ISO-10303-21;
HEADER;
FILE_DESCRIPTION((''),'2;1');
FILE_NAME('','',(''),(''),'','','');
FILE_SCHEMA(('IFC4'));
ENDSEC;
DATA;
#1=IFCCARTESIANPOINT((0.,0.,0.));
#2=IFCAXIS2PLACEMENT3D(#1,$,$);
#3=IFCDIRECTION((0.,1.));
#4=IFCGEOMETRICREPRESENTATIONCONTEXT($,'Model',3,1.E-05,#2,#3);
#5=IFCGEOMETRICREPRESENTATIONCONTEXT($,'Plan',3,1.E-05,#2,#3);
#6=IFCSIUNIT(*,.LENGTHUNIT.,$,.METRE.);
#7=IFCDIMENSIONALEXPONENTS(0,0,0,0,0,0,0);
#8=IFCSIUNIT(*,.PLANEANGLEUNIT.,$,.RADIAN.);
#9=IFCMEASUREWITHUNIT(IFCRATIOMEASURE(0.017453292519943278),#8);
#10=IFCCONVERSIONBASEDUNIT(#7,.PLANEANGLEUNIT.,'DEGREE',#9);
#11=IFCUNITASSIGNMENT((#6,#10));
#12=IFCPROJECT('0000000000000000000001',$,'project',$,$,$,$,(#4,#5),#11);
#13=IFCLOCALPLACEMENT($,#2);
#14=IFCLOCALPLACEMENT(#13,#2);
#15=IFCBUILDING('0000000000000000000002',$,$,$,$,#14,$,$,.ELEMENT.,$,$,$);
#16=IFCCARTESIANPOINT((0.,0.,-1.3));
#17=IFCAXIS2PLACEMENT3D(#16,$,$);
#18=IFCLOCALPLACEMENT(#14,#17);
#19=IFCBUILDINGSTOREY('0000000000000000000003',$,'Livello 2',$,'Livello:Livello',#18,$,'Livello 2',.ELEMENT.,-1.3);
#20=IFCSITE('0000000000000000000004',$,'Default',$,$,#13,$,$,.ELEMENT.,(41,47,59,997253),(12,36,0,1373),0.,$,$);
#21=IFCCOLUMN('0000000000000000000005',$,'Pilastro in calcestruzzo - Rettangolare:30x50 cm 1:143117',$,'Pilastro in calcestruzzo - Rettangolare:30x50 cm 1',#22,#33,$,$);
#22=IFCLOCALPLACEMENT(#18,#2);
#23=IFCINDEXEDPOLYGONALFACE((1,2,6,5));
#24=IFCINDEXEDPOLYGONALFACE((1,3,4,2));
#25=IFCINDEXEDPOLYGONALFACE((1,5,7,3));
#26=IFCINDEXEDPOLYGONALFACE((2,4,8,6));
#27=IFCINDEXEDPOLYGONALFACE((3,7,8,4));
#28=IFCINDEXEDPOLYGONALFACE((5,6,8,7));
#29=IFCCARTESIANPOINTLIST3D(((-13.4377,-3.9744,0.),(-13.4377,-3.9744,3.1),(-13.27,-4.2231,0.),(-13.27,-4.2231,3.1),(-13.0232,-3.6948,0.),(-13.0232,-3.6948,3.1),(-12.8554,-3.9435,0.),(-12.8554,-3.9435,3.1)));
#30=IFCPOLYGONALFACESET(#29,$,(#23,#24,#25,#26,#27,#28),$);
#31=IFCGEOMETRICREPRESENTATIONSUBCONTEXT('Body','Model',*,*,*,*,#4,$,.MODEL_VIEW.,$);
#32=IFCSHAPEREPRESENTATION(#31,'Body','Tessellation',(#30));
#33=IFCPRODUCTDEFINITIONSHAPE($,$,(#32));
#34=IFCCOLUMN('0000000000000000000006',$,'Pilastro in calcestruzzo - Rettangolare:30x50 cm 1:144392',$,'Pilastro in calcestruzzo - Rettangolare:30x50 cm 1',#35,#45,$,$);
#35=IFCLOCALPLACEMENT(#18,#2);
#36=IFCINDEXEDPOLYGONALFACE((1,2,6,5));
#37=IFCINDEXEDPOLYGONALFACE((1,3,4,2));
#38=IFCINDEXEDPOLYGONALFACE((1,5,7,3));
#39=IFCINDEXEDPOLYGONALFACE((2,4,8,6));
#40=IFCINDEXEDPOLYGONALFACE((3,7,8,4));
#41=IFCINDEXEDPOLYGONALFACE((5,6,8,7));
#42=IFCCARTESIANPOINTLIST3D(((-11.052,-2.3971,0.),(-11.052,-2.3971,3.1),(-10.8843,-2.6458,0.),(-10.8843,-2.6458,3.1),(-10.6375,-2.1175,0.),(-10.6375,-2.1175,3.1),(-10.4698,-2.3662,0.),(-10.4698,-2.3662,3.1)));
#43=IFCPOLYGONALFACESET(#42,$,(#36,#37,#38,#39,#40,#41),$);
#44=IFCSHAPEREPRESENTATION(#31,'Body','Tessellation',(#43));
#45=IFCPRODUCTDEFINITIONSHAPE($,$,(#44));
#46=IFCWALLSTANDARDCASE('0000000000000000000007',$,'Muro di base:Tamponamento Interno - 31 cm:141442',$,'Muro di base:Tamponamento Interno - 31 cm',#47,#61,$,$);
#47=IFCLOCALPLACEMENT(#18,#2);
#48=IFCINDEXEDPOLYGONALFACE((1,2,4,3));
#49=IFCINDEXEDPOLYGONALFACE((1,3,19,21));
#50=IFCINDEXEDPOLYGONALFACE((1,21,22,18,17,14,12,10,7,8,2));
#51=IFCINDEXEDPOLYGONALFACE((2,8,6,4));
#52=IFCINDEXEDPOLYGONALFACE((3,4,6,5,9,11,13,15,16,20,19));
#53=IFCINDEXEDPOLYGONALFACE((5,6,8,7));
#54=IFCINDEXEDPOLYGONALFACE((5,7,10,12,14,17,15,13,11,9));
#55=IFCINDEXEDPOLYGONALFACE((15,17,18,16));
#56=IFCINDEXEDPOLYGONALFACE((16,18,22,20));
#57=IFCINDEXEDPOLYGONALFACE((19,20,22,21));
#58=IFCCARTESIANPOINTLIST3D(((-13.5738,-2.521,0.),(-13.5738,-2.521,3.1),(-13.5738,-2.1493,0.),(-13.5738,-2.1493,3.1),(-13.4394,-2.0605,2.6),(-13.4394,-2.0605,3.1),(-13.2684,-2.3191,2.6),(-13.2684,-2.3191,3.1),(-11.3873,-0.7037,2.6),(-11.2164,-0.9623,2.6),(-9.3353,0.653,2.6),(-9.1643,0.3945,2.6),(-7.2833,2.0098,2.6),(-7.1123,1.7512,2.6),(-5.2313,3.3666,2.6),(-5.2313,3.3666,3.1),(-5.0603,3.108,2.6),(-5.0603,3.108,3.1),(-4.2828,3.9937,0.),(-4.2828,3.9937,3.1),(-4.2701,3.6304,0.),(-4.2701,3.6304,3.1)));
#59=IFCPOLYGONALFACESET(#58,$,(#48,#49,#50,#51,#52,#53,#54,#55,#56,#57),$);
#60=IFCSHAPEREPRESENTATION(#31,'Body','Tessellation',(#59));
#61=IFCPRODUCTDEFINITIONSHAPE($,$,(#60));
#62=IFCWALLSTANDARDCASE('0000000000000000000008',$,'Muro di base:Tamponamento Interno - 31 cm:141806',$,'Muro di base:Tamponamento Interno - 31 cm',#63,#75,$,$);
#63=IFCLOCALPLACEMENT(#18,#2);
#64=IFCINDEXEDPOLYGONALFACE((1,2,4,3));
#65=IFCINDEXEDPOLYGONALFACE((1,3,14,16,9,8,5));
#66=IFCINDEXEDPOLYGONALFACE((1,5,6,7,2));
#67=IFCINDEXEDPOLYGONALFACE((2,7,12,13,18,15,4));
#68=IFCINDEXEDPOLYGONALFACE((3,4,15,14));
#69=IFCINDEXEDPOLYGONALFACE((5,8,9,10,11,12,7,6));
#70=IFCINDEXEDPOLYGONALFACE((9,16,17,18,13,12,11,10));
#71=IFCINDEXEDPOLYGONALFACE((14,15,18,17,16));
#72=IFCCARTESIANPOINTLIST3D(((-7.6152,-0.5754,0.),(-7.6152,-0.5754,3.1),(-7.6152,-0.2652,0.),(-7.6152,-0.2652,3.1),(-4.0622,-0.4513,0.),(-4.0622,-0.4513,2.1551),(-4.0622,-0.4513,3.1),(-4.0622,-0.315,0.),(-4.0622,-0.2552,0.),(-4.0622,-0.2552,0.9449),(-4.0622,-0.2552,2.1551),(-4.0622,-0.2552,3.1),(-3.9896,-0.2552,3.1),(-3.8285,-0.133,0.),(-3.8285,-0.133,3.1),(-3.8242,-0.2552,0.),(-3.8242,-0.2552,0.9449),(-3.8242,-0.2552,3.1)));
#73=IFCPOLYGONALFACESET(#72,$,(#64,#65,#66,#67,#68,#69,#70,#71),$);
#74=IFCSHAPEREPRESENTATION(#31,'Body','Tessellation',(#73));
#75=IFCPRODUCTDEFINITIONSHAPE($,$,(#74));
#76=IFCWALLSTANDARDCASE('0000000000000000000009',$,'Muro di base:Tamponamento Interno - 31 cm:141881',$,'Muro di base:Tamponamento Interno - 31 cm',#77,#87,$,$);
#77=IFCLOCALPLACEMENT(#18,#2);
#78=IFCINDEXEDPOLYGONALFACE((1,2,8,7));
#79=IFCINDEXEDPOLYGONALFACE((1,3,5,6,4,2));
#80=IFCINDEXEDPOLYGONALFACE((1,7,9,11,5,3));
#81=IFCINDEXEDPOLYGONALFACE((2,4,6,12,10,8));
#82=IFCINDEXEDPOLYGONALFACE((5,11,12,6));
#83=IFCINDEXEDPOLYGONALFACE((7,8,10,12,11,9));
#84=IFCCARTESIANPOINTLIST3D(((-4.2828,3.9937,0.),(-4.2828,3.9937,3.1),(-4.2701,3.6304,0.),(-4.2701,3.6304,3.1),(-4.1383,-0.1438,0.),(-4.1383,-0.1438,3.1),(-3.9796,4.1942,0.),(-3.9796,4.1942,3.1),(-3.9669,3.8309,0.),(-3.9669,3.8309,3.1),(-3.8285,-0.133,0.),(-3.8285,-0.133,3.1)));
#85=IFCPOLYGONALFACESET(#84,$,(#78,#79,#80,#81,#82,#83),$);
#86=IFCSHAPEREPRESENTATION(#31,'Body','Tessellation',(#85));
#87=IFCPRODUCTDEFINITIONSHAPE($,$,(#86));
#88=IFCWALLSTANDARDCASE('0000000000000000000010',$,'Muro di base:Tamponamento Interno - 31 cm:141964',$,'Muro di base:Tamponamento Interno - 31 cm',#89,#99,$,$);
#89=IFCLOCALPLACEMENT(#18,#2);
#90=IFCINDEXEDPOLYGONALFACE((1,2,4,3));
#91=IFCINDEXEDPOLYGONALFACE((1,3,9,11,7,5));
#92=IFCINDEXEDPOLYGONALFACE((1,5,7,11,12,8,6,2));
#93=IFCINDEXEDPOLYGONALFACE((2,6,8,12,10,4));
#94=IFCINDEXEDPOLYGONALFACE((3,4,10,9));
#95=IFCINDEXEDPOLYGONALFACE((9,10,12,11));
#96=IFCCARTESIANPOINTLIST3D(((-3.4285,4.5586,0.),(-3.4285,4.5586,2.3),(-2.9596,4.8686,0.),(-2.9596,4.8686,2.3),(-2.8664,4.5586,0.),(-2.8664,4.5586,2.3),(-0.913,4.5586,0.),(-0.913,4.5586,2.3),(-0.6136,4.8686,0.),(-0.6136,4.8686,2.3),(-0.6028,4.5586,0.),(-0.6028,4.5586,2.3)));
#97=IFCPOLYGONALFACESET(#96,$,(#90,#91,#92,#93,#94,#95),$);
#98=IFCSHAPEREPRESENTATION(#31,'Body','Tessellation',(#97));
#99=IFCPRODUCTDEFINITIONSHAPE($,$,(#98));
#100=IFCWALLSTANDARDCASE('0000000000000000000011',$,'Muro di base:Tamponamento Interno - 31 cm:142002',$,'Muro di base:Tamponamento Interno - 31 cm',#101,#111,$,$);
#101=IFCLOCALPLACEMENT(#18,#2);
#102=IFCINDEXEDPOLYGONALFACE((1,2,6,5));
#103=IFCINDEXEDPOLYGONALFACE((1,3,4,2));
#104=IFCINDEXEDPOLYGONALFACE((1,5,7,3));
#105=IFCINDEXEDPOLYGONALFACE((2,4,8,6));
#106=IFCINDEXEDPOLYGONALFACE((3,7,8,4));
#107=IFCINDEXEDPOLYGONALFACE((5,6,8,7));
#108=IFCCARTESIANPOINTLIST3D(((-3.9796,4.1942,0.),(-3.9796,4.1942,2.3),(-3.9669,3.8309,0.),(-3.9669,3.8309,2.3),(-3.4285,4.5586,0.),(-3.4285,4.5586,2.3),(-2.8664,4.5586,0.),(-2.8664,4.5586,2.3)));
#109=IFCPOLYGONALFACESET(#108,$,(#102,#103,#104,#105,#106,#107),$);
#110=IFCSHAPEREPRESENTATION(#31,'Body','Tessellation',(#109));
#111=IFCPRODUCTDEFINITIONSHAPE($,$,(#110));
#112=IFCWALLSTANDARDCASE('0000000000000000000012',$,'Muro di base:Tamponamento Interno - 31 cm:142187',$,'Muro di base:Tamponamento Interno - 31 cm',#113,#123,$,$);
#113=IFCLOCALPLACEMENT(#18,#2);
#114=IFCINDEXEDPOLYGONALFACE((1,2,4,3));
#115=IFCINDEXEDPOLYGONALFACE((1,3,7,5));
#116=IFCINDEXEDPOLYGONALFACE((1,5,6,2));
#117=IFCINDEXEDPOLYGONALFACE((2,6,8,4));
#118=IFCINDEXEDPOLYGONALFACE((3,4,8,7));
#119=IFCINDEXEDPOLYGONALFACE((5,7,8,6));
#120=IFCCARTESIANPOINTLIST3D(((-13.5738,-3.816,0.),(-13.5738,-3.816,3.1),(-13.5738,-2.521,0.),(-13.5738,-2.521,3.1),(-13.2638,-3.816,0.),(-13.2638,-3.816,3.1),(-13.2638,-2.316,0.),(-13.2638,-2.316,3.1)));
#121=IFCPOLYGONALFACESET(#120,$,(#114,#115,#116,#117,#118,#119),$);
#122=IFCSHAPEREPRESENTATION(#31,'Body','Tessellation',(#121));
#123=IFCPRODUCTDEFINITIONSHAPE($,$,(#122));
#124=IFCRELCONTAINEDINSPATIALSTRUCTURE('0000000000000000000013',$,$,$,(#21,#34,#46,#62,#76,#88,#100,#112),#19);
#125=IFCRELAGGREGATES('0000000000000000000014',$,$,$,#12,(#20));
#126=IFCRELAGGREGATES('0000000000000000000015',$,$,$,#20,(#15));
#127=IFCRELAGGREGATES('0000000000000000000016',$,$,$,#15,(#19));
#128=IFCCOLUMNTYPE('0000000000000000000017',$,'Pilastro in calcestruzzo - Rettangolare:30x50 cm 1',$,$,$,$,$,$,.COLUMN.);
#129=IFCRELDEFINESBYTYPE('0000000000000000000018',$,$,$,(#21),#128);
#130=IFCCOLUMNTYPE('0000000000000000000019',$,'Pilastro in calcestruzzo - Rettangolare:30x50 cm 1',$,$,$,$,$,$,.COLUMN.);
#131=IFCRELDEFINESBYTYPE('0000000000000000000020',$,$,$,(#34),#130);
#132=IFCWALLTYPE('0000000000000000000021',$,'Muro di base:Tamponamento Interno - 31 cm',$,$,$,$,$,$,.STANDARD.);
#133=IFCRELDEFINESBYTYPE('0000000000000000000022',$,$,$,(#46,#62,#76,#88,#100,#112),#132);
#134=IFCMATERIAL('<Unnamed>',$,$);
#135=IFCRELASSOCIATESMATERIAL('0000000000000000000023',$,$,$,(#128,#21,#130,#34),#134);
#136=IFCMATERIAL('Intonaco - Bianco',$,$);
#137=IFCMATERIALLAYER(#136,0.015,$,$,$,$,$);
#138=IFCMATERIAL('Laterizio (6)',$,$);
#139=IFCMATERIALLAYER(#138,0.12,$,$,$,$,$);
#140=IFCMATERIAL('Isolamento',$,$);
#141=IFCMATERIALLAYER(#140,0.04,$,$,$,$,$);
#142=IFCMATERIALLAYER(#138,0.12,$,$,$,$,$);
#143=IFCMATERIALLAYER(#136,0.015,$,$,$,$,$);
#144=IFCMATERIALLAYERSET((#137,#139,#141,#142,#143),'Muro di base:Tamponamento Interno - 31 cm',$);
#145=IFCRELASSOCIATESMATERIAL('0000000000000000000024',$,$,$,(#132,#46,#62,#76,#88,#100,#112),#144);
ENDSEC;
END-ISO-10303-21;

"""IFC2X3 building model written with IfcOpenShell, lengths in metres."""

from ifc_helpers import new_model, entity, si_unit, converted_unit, direction, frame, frame_2d, origin, origin_2d_with_axis, place, context, subcontext, project, spatial, polyline, rectangle, outline, extrude, clip, bounded_halfspace, source, transform, mapped, material, layer, layer_set, layer_usage, type_object, type_shapes, element, save


model = new_model("IFC2X3")

# Units and contexts
model_context = context("Model", 3, precision=1e-05, world=origin(), true_north=direction((0.0, 1.0)))
plan_context = context("Plan", 3, precision=1e-05, world=origin(), true_north=direction((0.0, 1.0)))
body_context = subcontext(model_context, "Body", "Model", "MODEL_VIEW")
ifc_project = project(units=[si_unit("LENGTHUNIT", "METRE"), converted_unit("PLANEANGLEUNIT", "DEGREE", entity("IfcRatioMeasure", 0.017453292519943278), si_unit("PLANEANGLEUNIT", "RADIAN"), dimensions=[0, 0, 0, 0, 0, 0, 0])], contexts=[model_context, plan_context])

# Site, building, storey
site_placement = place(None, origin())
site = spatial("IfcSite", under=ifc_project, at=site_placement, Name="Default", CompositionType="ELEMENT", RefLatitude=(41, 47, 59, 997253), RefLongitude=(12, 36, 0, 1373), RefElevation=0.0)
building_placement = place(site_placement, origin())
building = spatial("IfcBuilding", under=site, at=building_placement, CompositionType="ELEMENT")
storey_placement = place(building_placement, frame((0.0, 0.0, -1.3)))
storey = spatial("IfcBuildingStorey", under=building, at=storey_placement, Name="Livello 2", ObjectType="Livello:Livello", LongName="Livello 2", CompositionType="ELEMENT", Elevation=-1.3)

# Columns
ifc_material_1 = material(Name="<Unnamed>")
column_type_1 = type_object("IfcColumnType", Name="Pilastro in calcestruzzo - Rettangolare:30x50 cm 1", PredefinedType="COLUMN", material=ifc_material_1)
shared_shape_1 = source(origin(), body_context, "Body", "SweptSolid", [
    extrude(rectangle(XDim=0.3, YDim=0.5, at=origin_2d_with_axis()), frame((-13.1466, -3.959, -1.3), z_axis=(0.0, 0.0, 1.0), x_axis=(-0.559193, 0.829038, 0.0)), (0.0, 0.0, 1.0), 3.1),
])
type_shapes(column_type_1, [shared_shape_1])
column_1_placement = place(storey_placement, frame((0.0, 0.0, 1.3)))
element("IfcColumn", 1, at=column_1_placement, inside=storey, type_object=column_type_1, material=ifc_material_1, Name="Pilastro in calcestruzzo - Rettangolare:30x50 cm 1:143117", ObjectType="Pilastro in calcestruzzo - Rettangolare:30x50 cm 1", context=body_context, shape_type="MappedRepresentation", body=[
    mapped(shared_shape_1, transform((0.0, 0.0, 0.0), scale=1.0)),
])
column_type_2 = type_object("IfcColumnType", Name="Pilastro in calcestruzzo - Rettangolare:30x50 cm 1", PredefinedType="COLUMN", material=ifc_material_1)
shared_shape_2 = source(origin(), body_context, "Body", "SweptSolid", [
    extrude(rectangle(XDim=0.3, YDim=0.5, at=frame_2d((0.0, 0.0), x_axis=(1.0, 0.0))), frame((-10.7609, -2.3816, -1.3), z_axis=(0.0, 0.0, 1.0), x_axis=(-0.559193, 0.829038, 0.0)), (0.0, 0.0, 1.0), 3.1),
])
type_shapes(column_type_2, [shared_shape_2])
column_2_placement = place(storey_placement, frame((0.0, 0.0, 1.3)))
element("IfcColumn", 2, at=column_2_placement, inside=storey, type_object=column_type_2, material=ifc_material_1, Name="Pilastro in calcestruzzo - Rettangolare:30x50 cm 1:144392", ObjectType="Pilastro in calcestruzzo - Rettangolare:30x50 cm 1", context=body_context, shape_type="MappedRepresentation", body=[
    mapped(shared_shape_2, transform((0.0, 0.0, 0.0), scale=1.0)),
])

# Shared definitions
ifc_material_2 = material(Name="Intonaco - Bianco")

# Wall, openings
ifc_layer_1 = layer(ifc_material_2, 0.015)
ifc_material_3 = material(Name="Laterizio (6)")
ifc_layer_2 = layer(ifc_material_3, 0.12)
ifc_material_4 = material(Name="Isolamento")
ifc_layer_3 = layer(ifc_material_4, 0.04)
ifc_layer_4 = layer(ifc_material_3, 0.12)
ifc_layer_5 = layer(ifc_material_2, 0.015)
ifc_layer_set_1 = layer_set([ifc_layer_1, ifc_layer_2, ifc_layer_3, ifc_layer_4, ifc_layer_5], Name="Muro di base:Tamponamento Interno - 31 cm")
ifc_layer_usage_1 = layer_usage(ifc_layer_set_1, "AXIS2", "POSITIVE", -0.155)
wall_type_1 = type_object("IfcWallType", Name="Muro di base:Tamponamento Interno - 31 cm", PredefinedType="STANDARD", material=ifc_layer_set_1)
wall_1_placement = place(storey_placement, frame((-13.6593, -2.3917, 0.0), z_axis=(0.0, 0.0, 1.0), x_axis=(0.834155, 0.55153, 0.0)))
wall_1 = element("IfcWallStandardCase", 3, at=wall_1_placement, inside=storey, type_object=wall_type_1, material=ifc_layer_usage_1, Name="Muro di base:Tamponamento Interno - 31 cm:141442", ObjectType="Muro di base:Tamponamento Interno - 31 cm", context=body_context, shape_type="SweptSolid", body=[
    extrude(outline(polyline([(11.1534, -0.155), (11.3432, 0.155), (0.205, 0.155), (0.0, -0.155), (0.3716, -0.155), (6.7716, -0.155), (7.1433, -0.155), (11.1534, -0.155)])), origin(), (0.0, 0.0, 1.0), 3.1),
])
opening_1_placement = place(wall_1_placement, frame((12.713, -5.5384, 0.0), z_axis=(0.0, 0.0, 1.0), x_axis=(0.834155, -0.55153, 0.0)))
element("IfcOpeningElement", 4, at=opening_1_placement, cuts=wall_1, ObjectType="Opening", context=body_context, shape_type="SweptSolid", body=[
    extrude(rectangle(XDim=0.5, YDim=2.46, at=frame_2d((0.0, 0.0), x_axis=(1.0, 0.0))), frame((-12.2424, -1.6407, 2.85), z_axis=(-0.55153, 0.834155, 0.0), x_axis=(0.0, 0.0, -1.0)), (0.0, 0.0, 1.0), 0.31),
])
opening_2_placement = place(wall_1_placement, frame((12.713, -5.5384, 2.3), z_axis=(0.0, 0.0, 1.0), x_axis=(0.834155, -0.55153, 0.0)))
element("IfcOpeningElement", 5, at=opening_2_placement, cuts=wall_1, ObjectType="Opening", context=body_context, shape_type="SweptSolid", body=[
    extrude(rectangle(XDim=0.5, YDim=2.46, at=frame_2d((0.0, 0.0), x_axis=(1.0, 0.0))), frame((-8.1383, 1.0728, 0.55), z_axis=(-0.55153, 0.834155, 0.0), x_axis=(0.0, 0.0, -1.0)), (0.0, 0.0, 1.0), 0.31),
])
opening_3_placement = place(wall_1_placement, frame((12.713, -5.5384, 2.3), z_axis=(0.0, 0.0, 1.0), x_axis=(0.834155, -0.55153, 0.0)))
element("IfcOpeningElement", 6, at=opening_3_placement, cuts=wall_1, ObjectType="Opening", context=body_context, shape_type="SweptSolid", body=[
    extrude(rectangle(XDim=0.5, YDim=2.46, at=frame_2d((0.0, 0.0), x_axis=(0.0, 1.0))), frame((-6.0863, 2.4296, 0.55), z_axis=(-0.55153, 0.834155, 0.0), x_axis=(0.834155, 0.55153, 0.0)), (0.0, 0.0, 1.0), 0.31),
])
opening_4_placement = place(wall_1_placement, frame((12.713, -5.5384, 2.3), z_axis=(0.0, 0.0, 1.0), x_axis=(0.834155, -0.55153, 0.0)))
element("IfcOpeningElement", 7, at=opening_4_placement, cuts=wall_1, ObjectType="Opening", context=body_context, shape_type="SweptSolid", body=[
    extrude(rectangle(XDim=0.5, YDim=2.46, at=origin_2d_with_axis()), frame((-10.1904, -0.2839, 0.55), z_axis=(-0.55153, 0.834155, 0.0), x_axis=(0.0, 0.0, -1.0)), (0.0, 0.0, 1.0), 0.31),
])

# Walls
ifc_layer_usage_2 = layer_usage(ifc_layer_set_1, "AXIS2", "POSITIVE", -0.155)
wall_2_placement = place(storey_placement, frame((-7.6206, -0.4205, 0.0), z_axis=(0.0, 0.0, 1.0), x_axis=(0.999391, 0.034899, 0.0)))
element("IfcWallStandardCase", 8, at=wall_2_placement, inside=storey, type_object=wall_type_1, material=ifc_layer_usage_2, Name="Muro di base:Tamponamento Interno - 31 cm:141806", ObjectType="Muro di base:Tamponamento Interno - 31 cm", context=body_context, shape_type="Clipping", body=[
    clip(clip(extrude(outline(polyline([(0.0108, 0.155), (0.0, -0.155), (3.5552, -0.155), (3.562, 0.041), (3.7998, 0.0327), (3.7998, 0.155), (3.4898, 0.155), (0.0108, 0.155)])), origin(), (0.0, 0.0, 1.0), 3.1), bounded_halfspace(frame((3.562, 0.041, 3.1), z_axis=(0.034899, 0.999391, 0.0), x_axis=(0.0, 0.0, -1.0)), True, frame((3.562, 0.041, 3.1), z_axis=(0.034899, 0.999391, 0.0), x_axis=(0.0, 0.0, -1.0)), polyline([(0.0, 0.0), (0.0, -0.0725), (0.9449, -0.0725), (0.9449, 0.0), (0.0, 0.0)]))), bounded_halfspace(frame((3.562, 0.041, 0.0), z_axis=(-0.999391, 0.034899, 0.0), x_axis=(0.0, 0.0, -1.0)), True, frame((3.562, 0.041, 0.0), z_axis=(-0.999391, 0.034899, 0.0), x_axis=(0.0, 0.0, -1.0)), polyline([(0.0, 0.0), (0.0, 0.0598), (-0.9449, 0.0598), (-0.9449, 0.0), (0.0, 0.0)]))),
])
ifc_layer_usage_3 = layer_usage(ifc_layer_set_1, "AXIS2", "NEGATIVE", 0.155)
wall_3_placement = place(storey_placement, frame((-3.9834, -0.1384, 0.0), z_axis=(0.0, 0.0, 1.0), x_axis=(-0.034899, 0.999391, 0.0)))
element("IfcWallStandardCase", 9, at=wall_3_placement, inside=storey, type_object=wall_type_1, material=ifc_layer_usage_3, Name="Muro di base:Tamponamento Interno - 31 cm:141881", ObjectType="Muro di base:Tamponamento Interno - 31 cm", context=body_context, shape_type="SweptSolid", body=[
    extrude(outline(polyline([(4.3298, -0.155), (4.14, 0.155), (3.7765, 0.155), (0.0, 0.155), (0.0, -0.155), (3.9663, -0.155), (4.3298, -0.155)])), origin(), (0.0, 0.0, 1.0), 3.1),
])
ifc_layer_usage_4 = layer_usage(ifc_layer_set_1, "AXIS2", "NEGATIVE", 0.155)
wall_4_placement = place(storey_placement, frame((-0.6028, 4.7136, 0.0), z_axis=(0.0, 0.0, 1.0), x_axis=(-1.0, 0.0, 0.0)))
element("IfcWallStandardCase", 10, at=wall_4_placement, inside=storey, type_object=wall_type_1, material=ifc_layer_usage_4, Name="Muro di base:Tamponamento Interno - 31 cm:141964", ObjectType="Muro di base:Tamponamento Interno - 31 cm", context=body_context, shape_type="SweptSolid", body=[
    extrude(outline(polyline([(2.3568, -0.155), (2.8257, 0.155), (2.2636, 0.155), (0.3102, 0.155), (0.0, 0.155), (0.0108, -0.155), (2.3568, -0.155)])), origin(), (0.0, 0.0, 1.0), 2.3),
])
ifc_layer_usage_5 = layer_usage(ifc_layer_set_1, "AXIS2", "NEGATIVE", 0.155)
wall_5_placement = place(storey_placement, frame((-2.9519, 4.6878, 0.0), z_axis=(0.0, 0.0, 1.0), x_axis=(-0.834155, -0.55153, 0.0)))
element("IfcWallStandardCase", 11, at=wall_5_placement, inside=storey, type_object=wall_type_1, material=ifc_layer_usage_5, Name="Muro di base:Tamponamento Interno - 31 cm:142002", ObjectType="Muro di base:Tamponamento Interno - 31 cm", context=body_context, shape_type="SweptSolid", body=[
    extrude(outline(polyline([(1.1296, -0.155), (1.3193, 0.155), (0.0, 0.155), (0.4689, -0.155), (1.1296, -0.155)])), origin(), (0.0, 0.0, 1.0), 2.3),
])
ifc_layer_usage_6 = layer_usage(ifc_layer_set_1, "AXIS2", "NEGATIVE", 0.155)
wall_6_placement = place(storey_placement, frame((-13.4188, -2.316, 0.0), z_axis=(0.0, 0.0, 1.0), x_axis=(0.0, -1.0, 0.0)))
element("IfcWallStandardCase", 12, at=wall_6_placement, inside=storey, type_object=wall_type_1, material=ifc_layer_usage_6, Name="Muro di base:Tamponamento Interno - 31 cm:142187", ObjectType="Muro di base:Tamponamento Interno - 31 cm", context=body_context, shape_type="SweptSolid", body=[
    extrude(outline(polyline([(1.5, -0.155), (1.5, 0.155), (0.0, 0.155), (0.205, -0.155), (1.5, -0.155)])), origin(), (0.0, 0.0, 1.0), 3.1),
])

save(model, "model.ifc")
